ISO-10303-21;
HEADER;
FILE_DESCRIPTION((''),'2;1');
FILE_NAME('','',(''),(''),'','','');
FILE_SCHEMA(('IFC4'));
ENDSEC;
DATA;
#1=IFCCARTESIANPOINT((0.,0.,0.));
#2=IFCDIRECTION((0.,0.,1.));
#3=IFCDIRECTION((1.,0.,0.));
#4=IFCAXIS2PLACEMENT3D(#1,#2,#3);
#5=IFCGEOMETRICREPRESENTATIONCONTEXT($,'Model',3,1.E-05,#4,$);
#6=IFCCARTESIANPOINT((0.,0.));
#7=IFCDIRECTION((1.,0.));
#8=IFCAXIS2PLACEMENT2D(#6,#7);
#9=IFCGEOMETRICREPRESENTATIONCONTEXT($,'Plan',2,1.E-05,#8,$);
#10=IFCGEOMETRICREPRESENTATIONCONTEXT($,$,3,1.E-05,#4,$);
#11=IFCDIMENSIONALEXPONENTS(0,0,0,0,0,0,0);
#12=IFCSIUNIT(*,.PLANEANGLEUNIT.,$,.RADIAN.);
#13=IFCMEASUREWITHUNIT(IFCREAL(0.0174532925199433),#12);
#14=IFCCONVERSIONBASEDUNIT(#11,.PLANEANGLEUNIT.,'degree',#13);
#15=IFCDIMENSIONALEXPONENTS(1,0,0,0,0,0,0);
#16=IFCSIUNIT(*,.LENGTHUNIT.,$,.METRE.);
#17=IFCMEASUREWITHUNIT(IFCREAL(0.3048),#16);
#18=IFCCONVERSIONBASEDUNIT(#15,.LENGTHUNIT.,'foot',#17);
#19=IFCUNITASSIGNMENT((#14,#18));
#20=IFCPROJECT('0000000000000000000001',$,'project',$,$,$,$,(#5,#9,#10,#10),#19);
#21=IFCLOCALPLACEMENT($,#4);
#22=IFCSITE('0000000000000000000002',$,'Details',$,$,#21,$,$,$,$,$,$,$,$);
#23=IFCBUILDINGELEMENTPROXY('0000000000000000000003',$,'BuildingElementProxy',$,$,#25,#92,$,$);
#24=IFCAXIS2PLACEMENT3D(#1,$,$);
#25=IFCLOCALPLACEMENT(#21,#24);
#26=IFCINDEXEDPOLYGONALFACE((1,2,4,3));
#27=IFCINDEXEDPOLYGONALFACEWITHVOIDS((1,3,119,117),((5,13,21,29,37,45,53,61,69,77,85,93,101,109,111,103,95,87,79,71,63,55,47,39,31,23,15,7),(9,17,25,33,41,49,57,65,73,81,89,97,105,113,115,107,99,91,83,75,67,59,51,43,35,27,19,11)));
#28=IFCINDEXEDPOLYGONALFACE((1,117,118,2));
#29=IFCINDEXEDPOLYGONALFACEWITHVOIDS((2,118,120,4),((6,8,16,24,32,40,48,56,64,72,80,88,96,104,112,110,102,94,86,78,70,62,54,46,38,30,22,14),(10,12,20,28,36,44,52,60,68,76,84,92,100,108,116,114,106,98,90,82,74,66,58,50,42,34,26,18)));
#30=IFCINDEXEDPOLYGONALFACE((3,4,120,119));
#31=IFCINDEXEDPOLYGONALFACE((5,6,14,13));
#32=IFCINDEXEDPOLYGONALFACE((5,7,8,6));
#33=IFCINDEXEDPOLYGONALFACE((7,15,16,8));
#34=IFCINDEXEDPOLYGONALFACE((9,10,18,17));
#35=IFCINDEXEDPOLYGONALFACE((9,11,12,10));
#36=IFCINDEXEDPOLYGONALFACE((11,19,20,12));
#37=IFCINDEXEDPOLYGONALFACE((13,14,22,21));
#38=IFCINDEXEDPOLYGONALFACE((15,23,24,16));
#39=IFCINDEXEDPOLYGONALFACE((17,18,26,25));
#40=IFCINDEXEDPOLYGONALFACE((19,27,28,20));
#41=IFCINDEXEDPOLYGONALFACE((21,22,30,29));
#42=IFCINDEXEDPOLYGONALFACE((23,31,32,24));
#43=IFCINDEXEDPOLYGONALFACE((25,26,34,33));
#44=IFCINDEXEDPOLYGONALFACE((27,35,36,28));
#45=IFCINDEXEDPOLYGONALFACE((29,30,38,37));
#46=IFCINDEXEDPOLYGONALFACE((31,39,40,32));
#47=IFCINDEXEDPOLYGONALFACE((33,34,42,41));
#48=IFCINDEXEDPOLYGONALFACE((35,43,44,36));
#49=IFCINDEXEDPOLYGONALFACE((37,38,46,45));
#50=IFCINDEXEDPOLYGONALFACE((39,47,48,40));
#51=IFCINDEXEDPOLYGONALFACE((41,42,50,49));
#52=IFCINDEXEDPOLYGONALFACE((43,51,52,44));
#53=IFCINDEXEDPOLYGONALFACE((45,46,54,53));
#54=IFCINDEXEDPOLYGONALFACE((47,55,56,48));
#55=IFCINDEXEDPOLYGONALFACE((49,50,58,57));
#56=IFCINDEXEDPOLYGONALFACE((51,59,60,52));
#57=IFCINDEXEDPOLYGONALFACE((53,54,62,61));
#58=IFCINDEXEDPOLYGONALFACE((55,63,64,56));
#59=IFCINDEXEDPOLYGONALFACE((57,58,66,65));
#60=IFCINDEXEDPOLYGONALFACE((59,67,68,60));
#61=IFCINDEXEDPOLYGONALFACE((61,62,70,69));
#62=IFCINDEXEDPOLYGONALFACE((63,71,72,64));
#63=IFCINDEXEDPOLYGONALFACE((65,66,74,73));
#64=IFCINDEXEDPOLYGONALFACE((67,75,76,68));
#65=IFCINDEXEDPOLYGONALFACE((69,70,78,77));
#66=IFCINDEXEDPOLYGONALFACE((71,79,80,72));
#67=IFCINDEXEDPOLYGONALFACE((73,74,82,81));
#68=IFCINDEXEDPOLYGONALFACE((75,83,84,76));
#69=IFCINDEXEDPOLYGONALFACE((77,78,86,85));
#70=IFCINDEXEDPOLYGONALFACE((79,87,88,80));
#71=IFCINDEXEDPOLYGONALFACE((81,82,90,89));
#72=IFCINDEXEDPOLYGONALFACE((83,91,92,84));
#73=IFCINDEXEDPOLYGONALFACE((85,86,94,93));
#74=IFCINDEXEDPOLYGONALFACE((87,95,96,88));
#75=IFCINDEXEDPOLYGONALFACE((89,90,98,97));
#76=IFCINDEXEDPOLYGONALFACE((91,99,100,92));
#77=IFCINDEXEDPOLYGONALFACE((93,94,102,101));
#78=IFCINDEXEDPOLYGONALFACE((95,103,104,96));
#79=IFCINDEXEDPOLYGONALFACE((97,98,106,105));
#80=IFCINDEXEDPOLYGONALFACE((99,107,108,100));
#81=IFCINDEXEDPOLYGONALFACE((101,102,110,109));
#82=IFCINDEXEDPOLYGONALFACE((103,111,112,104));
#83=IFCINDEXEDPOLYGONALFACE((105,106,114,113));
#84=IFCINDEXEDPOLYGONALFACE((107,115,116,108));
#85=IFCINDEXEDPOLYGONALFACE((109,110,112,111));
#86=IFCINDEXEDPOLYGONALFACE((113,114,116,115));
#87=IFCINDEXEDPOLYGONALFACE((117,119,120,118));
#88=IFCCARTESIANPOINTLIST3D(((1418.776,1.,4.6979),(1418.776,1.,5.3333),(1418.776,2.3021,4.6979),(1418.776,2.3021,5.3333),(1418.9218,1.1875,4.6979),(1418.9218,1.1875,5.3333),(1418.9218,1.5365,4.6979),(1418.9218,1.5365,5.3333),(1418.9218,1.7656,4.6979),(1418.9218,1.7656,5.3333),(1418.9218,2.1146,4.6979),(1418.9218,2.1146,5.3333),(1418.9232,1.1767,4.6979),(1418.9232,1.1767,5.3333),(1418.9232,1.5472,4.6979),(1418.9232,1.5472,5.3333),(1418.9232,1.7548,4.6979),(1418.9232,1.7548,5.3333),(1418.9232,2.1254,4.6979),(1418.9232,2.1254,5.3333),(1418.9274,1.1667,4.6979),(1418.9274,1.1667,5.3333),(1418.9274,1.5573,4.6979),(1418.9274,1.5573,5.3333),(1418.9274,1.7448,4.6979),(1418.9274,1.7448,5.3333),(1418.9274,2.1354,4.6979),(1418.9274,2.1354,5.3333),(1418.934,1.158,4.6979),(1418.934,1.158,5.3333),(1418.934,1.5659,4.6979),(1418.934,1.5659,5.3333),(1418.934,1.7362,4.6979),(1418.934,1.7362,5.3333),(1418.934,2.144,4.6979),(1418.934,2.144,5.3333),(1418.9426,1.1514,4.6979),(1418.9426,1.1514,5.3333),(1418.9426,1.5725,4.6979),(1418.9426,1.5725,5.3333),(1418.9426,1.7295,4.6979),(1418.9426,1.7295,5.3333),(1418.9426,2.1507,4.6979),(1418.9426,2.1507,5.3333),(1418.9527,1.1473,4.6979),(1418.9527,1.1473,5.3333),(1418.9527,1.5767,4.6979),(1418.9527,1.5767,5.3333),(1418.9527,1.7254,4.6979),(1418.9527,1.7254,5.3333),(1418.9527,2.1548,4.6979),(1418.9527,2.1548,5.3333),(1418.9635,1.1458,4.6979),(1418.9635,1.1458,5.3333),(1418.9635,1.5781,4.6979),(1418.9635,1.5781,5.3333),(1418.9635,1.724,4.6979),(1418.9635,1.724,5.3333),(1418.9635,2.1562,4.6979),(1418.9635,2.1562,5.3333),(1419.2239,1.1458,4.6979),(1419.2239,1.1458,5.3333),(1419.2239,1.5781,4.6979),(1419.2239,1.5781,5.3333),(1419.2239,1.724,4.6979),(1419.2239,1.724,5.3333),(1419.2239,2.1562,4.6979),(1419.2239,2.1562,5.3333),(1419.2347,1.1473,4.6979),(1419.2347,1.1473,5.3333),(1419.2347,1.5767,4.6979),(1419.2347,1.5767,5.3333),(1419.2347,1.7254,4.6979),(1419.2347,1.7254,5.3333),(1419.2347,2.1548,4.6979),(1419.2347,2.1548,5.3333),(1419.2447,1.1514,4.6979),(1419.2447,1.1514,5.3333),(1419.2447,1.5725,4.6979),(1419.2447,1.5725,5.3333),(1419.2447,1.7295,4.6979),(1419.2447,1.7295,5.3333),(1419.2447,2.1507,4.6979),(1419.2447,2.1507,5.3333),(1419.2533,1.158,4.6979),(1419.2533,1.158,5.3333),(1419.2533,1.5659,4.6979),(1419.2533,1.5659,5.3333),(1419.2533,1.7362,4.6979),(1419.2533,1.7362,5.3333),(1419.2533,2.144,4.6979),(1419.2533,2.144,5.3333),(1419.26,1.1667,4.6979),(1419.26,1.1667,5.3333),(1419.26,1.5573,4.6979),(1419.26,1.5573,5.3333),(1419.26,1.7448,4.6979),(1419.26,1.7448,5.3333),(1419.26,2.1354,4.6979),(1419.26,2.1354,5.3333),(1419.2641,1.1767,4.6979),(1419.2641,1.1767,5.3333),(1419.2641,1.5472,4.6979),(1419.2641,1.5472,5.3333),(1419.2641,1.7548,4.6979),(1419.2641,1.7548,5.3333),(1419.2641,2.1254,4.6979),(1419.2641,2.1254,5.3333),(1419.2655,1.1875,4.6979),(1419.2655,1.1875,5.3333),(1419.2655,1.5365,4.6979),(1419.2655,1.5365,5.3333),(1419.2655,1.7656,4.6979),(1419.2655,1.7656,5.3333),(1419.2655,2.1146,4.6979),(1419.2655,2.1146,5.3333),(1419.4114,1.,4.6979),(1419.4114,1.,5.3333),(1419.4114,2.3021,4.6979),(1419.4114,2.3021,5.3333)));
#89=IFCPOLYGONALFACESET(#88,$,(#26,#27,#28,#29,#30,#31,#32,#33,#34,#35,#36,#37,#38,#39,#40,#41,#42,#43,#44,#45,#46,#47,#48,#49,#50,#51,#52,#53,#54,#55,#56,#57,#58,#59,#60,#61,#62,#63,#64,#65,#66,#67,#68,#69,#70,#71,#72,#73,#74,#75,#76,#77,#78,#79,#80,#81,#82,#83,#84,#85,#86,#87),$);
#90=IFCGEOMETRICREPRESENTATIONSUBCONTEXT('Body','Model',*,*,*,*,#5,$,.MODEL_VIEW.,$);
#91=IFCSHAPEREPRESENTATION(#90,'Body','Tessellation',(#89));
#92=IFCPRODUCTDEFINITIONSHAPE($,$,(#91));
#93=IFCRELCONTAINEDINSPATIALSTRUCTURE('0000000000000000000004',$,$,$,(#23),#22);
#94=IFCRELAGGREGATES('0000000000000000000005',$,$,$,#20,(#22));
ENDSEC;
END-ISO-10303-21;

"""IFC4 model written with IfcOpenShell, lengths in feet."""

from ifc_helpers import new_model, entity, si_unit, converted_unit, frame, origin_with_axes, origin_2d_with_axis, place, context, subcontext, project, spatial, line, indexed_curve, outline, extrude, element, save


model = new_model("IFC4")

# Units and contexts
model_context = context("Model", 3, precision=1e-05, world=origin_with_axes())
plan_context = context("Plan", 2, precision=1e-05, world=origin_2d_with_axis())
context_of_model = context(None, 3, precision=1e-05, world=origin_with_axes())
body_context = subcontext(model_context, "Body", "Model", "MODEL_VIEW")
ifc_project = project(units=[converted_unit("PLANEANGLEUNIT", "degree", entity("IfcReal", 0.0174532925199433), si_unit("PLANEANGLEUNIT", "RADIAN"), dimensions=[0, 0, 0, 0, 0, 0, 0]), converted_unit("LENGTHUNIT", "foot", entity("IfcReal", 0.3048), si_unit("LENGTHUNIT", "METRE"), dimensions=[1, 0, 0, 0, 0, 0, 0])], contexts=[model_context, plan_context, context_of_model, context_of_model])

# Site
site_placement = place(None, origin_with_axes())
site = spatial("IfcSite", under=ifc_project, at=site_placement, Name="Details")

# Building element proxy
proxy_1_placement = place(site_placement, frame((1419.0936, 2.3021, 4.6979), z_axis=(0.0, 0.0, 1.0), x_axis=(0.0, 1.0, 0.0)))
element("IfcBuildingElementProxy", 1, at=proxy_1_placement, inside=site, Name="BuildingElementProxy", context=body_context, shape_type="SweptSolid", body=[
    extrude(outline(indexed_curve([(-0.3177, -0.651), (0.3177, -0.651), (0.3177, 0.651), (-0.3177, 0.651), (0.1719, -0.1146), (0.1719, -0.4635), (0.1705, -0.4743), (0.1663, -0.4844), (0.1597, -0.493), (0.151, -0.4996), (0.141, -0.5038), (0.1302, -0.5052), (-0.1302, -0.5052), (-0.141, -0.5038), (-0.151, -0.4996), (-0.1597, -0.493), (-0.1663, -0.4844), (-0.1705, -0.4743), (-0.1719, -0.4635), (-0.1719, -0.1146), (-0.1705, -0.1038), (-0.1663, -0.0938), (-0.1597, -0.0851), (-0.151, -0.0785), (-0.141, -0.0743), (-0.1302, -0.0729), (0.1302, -0.0729), (0.141, -0.0743), (0.151, -0.0785), (0.1597, -0.0851), (0.1663, -0.0938), (0.1705, -0.1038), (0.151, 0.0785), (0.141, 0.0743), (0.1302, 0.0729), (-0.1302, 0.0729), (-0.141, 0.0743), (-0.151, 0.0785), (-0.1597, 0.0851), (-0.1663, 0.0937), (-0.1705, 0.1038), (-0.1719, 0.1146), (-0.1719, 0.4635), (-0.1705, 0.4743), (-0.1663, 0.4844), (-0.1597, 0.493), (-0.151, 0.4996), (-0.141, 0.5038), (-0.1302, 0.5052), (0.1302, 0.5052), (0.141, 0.5038), (0.151, 0.4996), (0.1597, 0.493), (0.1663, 0.4844), (0.1705, 0.4743), (0.1719, 0.4635), (0.1719, 0.1146), (0.1705, 0.1038), (0.1663, 0.0937), (0.1597, 0.0851)], segments=[line(4, 3), line(3, 2), line(2, 1), line(1, 4)], self_intersect=False), holes=[indexed_curve([(-0.3177, -0.651), (0.3177, -0.651), (0.3177, 0.651), (-0.3177, 0.651), (0.1719, -0.1146), (0.1719, -0.4635), (0.1705, -0.4743), (0.1663, -0.4844), (0.1597, -0.493), (0.151, -0.4996), (0.141, -0.5038), (0.1302, -0.5052), (-0.1302, -0.5052), (-0.141, -0.5038), (-0.151, -0.4996), (-0.1597, -0.493), (-0.1663, -0.4844), (-0.1705, -0.4743), (-0.1719, -0.4635), (-0.1719, -0.1146), (-0.1705, -0.1038), (-0.1663, -0.0938), (-0.1597, -0.0851), (-0.151, -0.0785), (-0.141, -0.0743), (-0.1302, -0.0729), (0.1302, -0.0729), (0.141, -0.0743), (0.151, -0.0785), (0.1597, -0.0851), (0.1663, -0.0938), (0.1705, -0.1038), (0.151, 0.0785), (0.141, 0.0743), (0.1302, 0.0729), (-0.1302, 0.0729), (-0.141, 0.0743), (-0.151, 0.0785), (-0.1597, 0.0851), (-0.1663, 0.0937), (-0.1705, 0.1038), (-0.1719, 0.1146), (-0.1719, 0.4635), (-0.1705, 0.4743), (-0.1663, 0.4844), (-0.1597, 0.493), (-0.151, 0.4996), (-0.141, 0.5038), (-0.1302, 0.5052), (0.1302, 0.5052), (0.141, 0.5038), (0.151, 0.4996), (0.1597, 0.493), (0.1663, 0.4844), (0.1705, 0.4743), (0.1719, 0.4635), (0.1719, 0.1146), (0.1705, 0.1038), (0.1663, 0.0937), (0.1597, 0.0851)], segments=[line(20, 19), line(19, 18), line(18, 17), line(17, 16), line(16, 15), line(15, 14), line(14, 13), line(13, 12), line(12, 11), line(11, 10), line(10, 9), line(9, 8), line(8, 7), line(7, 6), line(6, 5), line(5, 32), line(32, 31), line(31, 30), line(30, 29), line(29, 28), line(28, 27), line(27, 26), line(26, 25), line(25, 24), line(24, 23), line(23, 22), line(22, 21), line(21, 20)], self_intersect=False), indexed_curve([(-0.3177, -0.651), (0.3177, -0.651), (0.3177, 0.651), (-0.3177, 0.651), (0.1719, -0.1146), (0.1719, -0.4635), (0.1705, -0.4743), (0.1663, -0.4844), (0.1597, -0.493), (0.151, -0.4996), (0.141, -0.5038), (0.1302, -0.5052), (-0.1302, -0.5052), (-0.141, -0.5038), (-0.151, -0.4996), (-0.1597, -0.493), (-0.1663, -0.4844), (-0.1705, -0.4743), (-0.1719, -0.4635), (-0.1719, -0.1146), (-0.1705, -0.1038), (-0.1663, -0.0938), (-0.1597, -0.0851), (-0.151, -0.0785), (-0.141, -0.0743), (-0.1302, -0.0729), (0.1302, -0.0729), (0.141, -0.0743), (0.151, -0.0785), (0.1597, -0.0851), (0.1663, -0.0938), (0.1705, -0.1038), (0.151, 0.0785), (0.141, 0.0743), (0.1302, 0.0729), (-0.1302, 0.0729), (-0.141, 0.0743), (-0.151, 0.0785), (-0.1597, 0.0851), (-0.1663, 0.0937), (-0.1705, 0.1038), (-0.1719, 0.1146), (-0.1719, 0.4635), (-0.1705, 0.4743), (-0.1663, 0.4844), (-0.1597, 0.493), (-0.151, 0.4996), (-0.141, 0.5038), (-0.1302, 0.5052), (0.1302, 0.5052), (0.141, 0.5038), (0.151, 0.4996), (0.1597, 0.493), (0.1663, 0.4844), (0.1705, 0.4743), (0.1719, 0.4635), (0.1719, 0.1146), (0.1705, 0.1038), (0.1663, 0.0937), (0.1597, 0.0851)], segments=[line(44, 43), line(43, 42), line(42, 41), line(41, 40), line(40, 39), line(39, 38), line(38, 37), line(37, 36), line(36, 35), line(35, 34), line(34, 33), line(33, 60), line(60, 59), line(59, 58), line(58, 57), line(57, 56), line(56, 55), line(55, 54), line(54, 53), line(53, 52), line(52, 51), line(51, 50), line(50, 49), line(49, 48), line(48, 47), line(47, 46), line(46, 45), line(45, 44)], self_intersect=False)]), frame((-0.651, 0.0, 0.0), z_axis=(0.0, 0.0, 1.0), x_axis=(0.0, -1.0, 0.0)), (0.0, 0.0, 1.0), 0.6354),
])

save(model, "model.ifc")
